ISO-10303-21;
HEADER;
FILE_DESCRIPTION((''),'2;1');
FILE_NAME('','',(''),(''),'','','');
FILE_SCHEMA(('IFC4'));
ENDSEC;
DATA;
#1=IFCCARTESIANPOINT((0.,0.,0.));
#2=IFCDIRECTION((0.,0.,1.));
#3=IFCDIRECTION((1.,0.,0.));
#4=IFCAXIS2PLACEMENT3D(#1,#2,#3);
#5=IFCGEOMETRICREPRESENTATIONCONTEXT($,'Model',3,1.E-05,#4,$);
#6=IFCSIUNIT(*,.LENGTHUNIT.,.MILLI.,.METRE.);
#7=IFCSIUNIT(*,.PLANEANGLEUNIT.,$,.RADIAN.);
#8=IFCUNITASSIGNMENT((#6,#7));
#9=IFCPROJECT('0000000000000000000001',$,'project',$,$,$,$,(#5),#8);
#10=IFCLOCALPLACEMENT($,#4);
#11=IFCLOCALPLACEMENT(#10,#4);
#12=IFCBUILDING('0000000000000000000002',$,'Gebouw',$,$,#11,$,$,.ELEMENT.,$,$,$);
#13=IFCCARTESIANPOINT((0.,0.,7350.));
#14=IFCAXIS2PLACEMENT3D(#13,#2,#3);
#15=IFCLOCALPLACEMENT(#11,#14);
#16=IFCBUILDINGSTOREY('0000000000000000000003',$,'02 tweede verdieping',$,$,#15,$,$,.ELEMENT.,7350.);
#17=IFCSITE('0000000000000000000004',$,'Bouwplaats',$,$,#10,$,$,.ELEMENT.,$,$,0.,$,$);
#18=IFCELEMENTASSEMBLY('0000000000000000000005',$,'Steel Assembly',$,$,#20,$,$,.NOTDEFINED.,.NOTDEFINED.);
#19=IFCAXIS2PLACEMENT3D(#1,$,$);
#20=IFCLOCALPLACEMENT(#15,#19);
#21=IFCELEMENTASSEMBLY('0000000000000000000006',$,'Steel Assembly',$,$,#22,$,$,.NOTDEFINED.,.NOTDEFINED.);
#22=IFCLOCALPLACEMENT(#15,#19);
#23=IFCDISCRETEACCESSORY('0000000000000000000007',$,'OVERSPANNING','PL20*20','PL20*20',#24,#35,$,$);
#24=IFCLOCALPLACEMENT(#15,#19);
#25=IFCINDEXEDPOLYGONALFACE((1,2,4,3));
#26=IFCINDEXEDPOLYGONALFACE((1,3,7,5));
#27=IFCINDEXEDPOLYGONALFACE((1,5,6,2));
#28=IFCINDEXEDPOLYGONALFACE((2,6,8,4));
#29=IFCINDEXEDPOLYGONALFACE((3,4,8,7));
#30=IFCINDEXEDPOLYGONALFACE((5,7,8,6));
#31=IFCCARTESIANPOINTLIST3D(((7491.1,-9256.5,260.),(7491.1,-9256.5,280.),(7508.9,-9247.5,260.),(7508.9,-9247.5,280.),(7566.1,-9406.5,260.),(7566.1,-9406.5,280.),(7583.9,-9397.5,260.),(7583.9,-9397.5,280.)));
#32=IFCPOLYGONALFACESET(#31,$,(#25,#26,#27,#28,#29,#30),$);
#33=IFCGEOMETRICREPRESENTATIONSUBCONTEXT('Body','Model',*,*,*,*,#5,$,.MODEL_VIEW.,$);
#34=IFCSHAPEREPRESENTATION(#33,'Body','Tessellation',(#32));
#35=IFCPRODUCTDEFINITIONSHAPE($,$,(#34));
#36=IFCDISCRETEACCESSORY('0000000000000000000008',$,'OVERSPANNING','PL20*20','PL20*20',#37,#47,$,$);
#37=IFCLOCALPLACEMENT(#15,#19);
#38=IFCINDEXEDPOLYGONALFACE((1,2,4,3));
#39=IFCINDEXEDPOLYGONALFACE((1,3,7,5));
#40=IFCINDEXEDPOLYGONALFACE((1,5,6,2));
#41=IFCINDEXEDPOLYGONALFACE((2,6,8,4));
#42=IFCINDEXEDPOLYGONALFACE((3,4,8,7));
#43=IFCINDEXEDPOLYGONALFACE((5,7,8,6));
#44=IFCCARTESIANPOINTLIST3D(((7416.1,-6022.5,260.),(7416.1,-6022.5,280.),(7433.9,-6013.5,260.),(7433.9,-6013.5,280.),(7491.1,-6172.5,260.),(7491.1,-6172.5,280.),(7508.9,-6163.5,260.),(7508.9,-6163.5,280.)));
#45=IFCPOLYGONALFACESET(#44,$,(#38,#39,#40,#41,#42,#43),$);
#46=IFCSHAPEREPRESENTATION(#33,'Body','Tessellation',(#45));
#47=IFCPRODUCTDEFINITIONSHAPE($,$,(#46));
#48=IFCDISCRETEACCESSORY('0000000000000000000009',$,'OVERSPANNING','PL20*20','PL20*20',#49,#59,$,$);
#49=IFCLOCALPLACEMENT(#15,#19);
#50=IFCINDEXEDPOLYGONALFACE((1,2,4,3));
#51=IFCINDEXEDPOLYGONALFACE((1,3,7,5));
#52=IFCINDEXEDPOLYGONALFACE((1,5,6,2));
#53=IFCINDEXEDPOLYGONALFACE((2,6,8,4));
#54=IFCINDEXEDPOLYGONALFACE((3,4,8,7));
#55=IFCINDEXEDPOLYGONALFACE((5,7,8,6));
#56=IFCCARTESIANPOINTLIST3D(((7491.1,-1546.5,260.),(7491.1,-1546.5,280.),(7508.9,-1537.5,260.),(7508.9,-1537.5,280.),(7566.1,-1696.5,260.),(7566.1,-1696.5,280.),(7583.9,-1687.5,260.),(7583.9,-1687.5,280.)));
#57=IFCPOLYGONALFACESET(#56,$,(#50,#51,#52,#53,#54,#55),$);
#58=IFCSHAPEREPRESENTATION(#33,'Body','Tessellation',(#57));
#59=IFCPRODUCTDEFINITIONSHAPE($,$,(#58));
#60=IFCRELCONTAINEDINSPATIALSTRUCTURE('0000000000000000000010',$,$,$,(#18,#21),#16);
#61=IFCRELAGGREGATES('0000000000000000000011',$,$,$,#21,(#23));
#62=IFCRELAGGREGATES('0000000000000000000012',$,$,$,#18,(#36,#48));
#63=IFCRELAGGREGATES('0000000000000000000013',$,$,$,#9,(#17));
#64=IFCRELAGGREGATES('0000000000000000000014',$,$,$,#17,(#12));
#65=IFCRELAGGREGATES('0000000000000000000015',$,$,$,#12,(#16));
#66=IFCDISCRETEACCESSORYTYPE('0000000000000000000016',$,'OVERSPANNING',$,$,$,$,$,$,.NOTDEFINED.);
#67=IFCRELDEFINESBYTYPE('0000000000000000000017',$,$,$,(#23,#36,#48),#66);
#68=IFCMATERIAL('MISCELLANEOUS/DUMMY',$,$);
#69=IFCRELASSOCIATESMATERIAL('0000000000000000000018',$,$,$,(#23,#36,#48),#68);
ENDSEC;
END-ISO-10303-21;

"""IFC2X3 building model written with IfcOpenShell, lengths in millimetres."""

from ifc_helpers import new_model, si_unit, frame, origin_with_axes, origin_2d_with_axis, place, context, subcontext, project, spatial, rectangle, extrude, material, type_object, element, aggregate, save


model = new_model("IFC2X3")

# Units and contexts
model_context = context("Model", 3, precision=1e-05, world=origin_with_axes())
body_context = subcontext(model_context, "Body", "Model", "MODEL_VIEW")
ifc_project = project(units=[si_unit("LENGTHUNIT", "METRE", prefix="MILLI"), si_unit("PLANEANGLEUNIT", "RADIAN")], contexts=[model_context])

# Site, building, storey
site_placement = place(None, origin_with_axes())
site = spatial("IfcSite", under=ifc_project, at=site_placement, Name="Bouwplaats", CompositionType="ELEMENT", RefElevation=0.0)
building_placement = place(site_placement, origin_with_axes())
building = spatial("IfcBuilding", under=site, at=building_placement, Name="Gebouw", CompositionType="ELEMENT")
storey_placement = place(building_placement, frame((0.0, 0.0, 7350.0), z_axis=(0.0, 0.0, 1.0), x_axis=(1.0, 0.0, 0.0)))
storey = spatial("IfcBuildingStorey", under=building, at=storey_placement, Name="02 tweede verdieping", CompositionType="ELEMENT", Elevation=7350.0)

# Element assembly
ifc_material_1 = material(Name="MISCELLANEOUS/DUMMY")
assembly_1_placement = place(storey_placement, origin_with_axes())
assembly_1 = element("IfcElementAssembly", 1, at=assembly_1_placement, inside=storey, Name="Steel Assembly", AssemblyPlace="NOTDEFINED", PredefinedType="NOTDEFINED")

# Shared definitions
discrete_accessory_type = type_object("IfcDiscreteAccessoryType", Name="OVERSPANNING")

# Element assembly, discrete accessory
assembly_2_placement = place(storey_placement, origin_with_axes())
assembly_2 = element("IfcElementAssembly", 2, at=assembly_2_placement, inside=storey, Name="Steel Assembly", AssemblyPlace="NOTDEFINED", PredefinedType="NOTDEFINED")
discrete_accessory_1_placement = place(assembly_2_placement, frame((7575.0, -9402.0, 270.0), z_axis=(-0.894427, -0.447214, 0.0), x_axis=(-0.447214, 0.894427, 0.0)))
discrete_accessory_1 = element("IfcDiscreteAccessory", 3, at=discrete_accessory_1_placement, type_object=discrete_accessory_type, material=ifc_material_1, Name="OVERSPANNING", Description="PL20*20", ObjectType="PL20*20", context=body_context, shape_type="SweptSolid", body=[
    extrude(rectangle(XDim=20.0, YDim=20.0, at=origin_2d_with_axis()), frame((167.7, 0.0, 0.0), z_axis=(-1.0, 0.0, 0.0), x_axis=(0.0, -1.0, 0.0)), (0.0, 0.0, 1.0), 167.7),
])
aggregate(assembly_2, [discrete_accessory_1])

# Discrete accessories
discrete_accessory_2_placement = place(assembly_1_placement, frame((7425.0, -6018.0, 270.0), z_axis=(0.894427, 0.447214, 0.0), x_axis=(0.447214, -0.894427, 0.0)))
discrete_accessory_2 = element("IfcDiscreteAccessory", 4, at=discrete_accessory_2_placement, type_object=discrete_accessory_type, material=ifc_material_1, Name="OVERSPANNING", Description="PL20*20", ObjectType="PL20*20", context=body_context, shape_type="SweptSolid", body=[
    extrude(rectangle(XDim=20.0, YDim=20.0, at=origin_2d_with_axis()), frame((167.7, 0.0, 0.0), z_axis=(-1.0, 0.0, 0.0), x_axis=(0.0, -1.0, 0.0)), (0.0, 0.0, 1.0), 167.7),
])
discrete_accessory_3_placement = place(assembly_1_placement, frame((7575.0, -1692.0, 270.0), z_axis=(-0.894427, -0.447214, 0.0), x_axis=(-0.447214, 0.894427, 0.0)))
discrete_accessory_3 = element("IfcDiscreteAccessory", 5, at=discrete_accessory_3_placement, type_object=discrete_accessory_type, material=ifc_material_1, Name="OVERSPANNING", Description="PL20*20", ObjectType="PL20*20", context=body_context, shape_type="SweptSolid", body=[
    extrude(rectangle(XDim=20.0, YDim=20.0, at=origin_2d_with_axis()), frame((167.7, 0.0, 0.0), z_axis=(-1.0, 0.0, 0.0), x_axis=(0.0, -1.0, 0.0)), (0.0, 0.0, 1.0), 167.7),
])
aggregate(assembly_1, [discrete_accessory_2, discrete_accessory_3])

save(model, "model.ifc")
